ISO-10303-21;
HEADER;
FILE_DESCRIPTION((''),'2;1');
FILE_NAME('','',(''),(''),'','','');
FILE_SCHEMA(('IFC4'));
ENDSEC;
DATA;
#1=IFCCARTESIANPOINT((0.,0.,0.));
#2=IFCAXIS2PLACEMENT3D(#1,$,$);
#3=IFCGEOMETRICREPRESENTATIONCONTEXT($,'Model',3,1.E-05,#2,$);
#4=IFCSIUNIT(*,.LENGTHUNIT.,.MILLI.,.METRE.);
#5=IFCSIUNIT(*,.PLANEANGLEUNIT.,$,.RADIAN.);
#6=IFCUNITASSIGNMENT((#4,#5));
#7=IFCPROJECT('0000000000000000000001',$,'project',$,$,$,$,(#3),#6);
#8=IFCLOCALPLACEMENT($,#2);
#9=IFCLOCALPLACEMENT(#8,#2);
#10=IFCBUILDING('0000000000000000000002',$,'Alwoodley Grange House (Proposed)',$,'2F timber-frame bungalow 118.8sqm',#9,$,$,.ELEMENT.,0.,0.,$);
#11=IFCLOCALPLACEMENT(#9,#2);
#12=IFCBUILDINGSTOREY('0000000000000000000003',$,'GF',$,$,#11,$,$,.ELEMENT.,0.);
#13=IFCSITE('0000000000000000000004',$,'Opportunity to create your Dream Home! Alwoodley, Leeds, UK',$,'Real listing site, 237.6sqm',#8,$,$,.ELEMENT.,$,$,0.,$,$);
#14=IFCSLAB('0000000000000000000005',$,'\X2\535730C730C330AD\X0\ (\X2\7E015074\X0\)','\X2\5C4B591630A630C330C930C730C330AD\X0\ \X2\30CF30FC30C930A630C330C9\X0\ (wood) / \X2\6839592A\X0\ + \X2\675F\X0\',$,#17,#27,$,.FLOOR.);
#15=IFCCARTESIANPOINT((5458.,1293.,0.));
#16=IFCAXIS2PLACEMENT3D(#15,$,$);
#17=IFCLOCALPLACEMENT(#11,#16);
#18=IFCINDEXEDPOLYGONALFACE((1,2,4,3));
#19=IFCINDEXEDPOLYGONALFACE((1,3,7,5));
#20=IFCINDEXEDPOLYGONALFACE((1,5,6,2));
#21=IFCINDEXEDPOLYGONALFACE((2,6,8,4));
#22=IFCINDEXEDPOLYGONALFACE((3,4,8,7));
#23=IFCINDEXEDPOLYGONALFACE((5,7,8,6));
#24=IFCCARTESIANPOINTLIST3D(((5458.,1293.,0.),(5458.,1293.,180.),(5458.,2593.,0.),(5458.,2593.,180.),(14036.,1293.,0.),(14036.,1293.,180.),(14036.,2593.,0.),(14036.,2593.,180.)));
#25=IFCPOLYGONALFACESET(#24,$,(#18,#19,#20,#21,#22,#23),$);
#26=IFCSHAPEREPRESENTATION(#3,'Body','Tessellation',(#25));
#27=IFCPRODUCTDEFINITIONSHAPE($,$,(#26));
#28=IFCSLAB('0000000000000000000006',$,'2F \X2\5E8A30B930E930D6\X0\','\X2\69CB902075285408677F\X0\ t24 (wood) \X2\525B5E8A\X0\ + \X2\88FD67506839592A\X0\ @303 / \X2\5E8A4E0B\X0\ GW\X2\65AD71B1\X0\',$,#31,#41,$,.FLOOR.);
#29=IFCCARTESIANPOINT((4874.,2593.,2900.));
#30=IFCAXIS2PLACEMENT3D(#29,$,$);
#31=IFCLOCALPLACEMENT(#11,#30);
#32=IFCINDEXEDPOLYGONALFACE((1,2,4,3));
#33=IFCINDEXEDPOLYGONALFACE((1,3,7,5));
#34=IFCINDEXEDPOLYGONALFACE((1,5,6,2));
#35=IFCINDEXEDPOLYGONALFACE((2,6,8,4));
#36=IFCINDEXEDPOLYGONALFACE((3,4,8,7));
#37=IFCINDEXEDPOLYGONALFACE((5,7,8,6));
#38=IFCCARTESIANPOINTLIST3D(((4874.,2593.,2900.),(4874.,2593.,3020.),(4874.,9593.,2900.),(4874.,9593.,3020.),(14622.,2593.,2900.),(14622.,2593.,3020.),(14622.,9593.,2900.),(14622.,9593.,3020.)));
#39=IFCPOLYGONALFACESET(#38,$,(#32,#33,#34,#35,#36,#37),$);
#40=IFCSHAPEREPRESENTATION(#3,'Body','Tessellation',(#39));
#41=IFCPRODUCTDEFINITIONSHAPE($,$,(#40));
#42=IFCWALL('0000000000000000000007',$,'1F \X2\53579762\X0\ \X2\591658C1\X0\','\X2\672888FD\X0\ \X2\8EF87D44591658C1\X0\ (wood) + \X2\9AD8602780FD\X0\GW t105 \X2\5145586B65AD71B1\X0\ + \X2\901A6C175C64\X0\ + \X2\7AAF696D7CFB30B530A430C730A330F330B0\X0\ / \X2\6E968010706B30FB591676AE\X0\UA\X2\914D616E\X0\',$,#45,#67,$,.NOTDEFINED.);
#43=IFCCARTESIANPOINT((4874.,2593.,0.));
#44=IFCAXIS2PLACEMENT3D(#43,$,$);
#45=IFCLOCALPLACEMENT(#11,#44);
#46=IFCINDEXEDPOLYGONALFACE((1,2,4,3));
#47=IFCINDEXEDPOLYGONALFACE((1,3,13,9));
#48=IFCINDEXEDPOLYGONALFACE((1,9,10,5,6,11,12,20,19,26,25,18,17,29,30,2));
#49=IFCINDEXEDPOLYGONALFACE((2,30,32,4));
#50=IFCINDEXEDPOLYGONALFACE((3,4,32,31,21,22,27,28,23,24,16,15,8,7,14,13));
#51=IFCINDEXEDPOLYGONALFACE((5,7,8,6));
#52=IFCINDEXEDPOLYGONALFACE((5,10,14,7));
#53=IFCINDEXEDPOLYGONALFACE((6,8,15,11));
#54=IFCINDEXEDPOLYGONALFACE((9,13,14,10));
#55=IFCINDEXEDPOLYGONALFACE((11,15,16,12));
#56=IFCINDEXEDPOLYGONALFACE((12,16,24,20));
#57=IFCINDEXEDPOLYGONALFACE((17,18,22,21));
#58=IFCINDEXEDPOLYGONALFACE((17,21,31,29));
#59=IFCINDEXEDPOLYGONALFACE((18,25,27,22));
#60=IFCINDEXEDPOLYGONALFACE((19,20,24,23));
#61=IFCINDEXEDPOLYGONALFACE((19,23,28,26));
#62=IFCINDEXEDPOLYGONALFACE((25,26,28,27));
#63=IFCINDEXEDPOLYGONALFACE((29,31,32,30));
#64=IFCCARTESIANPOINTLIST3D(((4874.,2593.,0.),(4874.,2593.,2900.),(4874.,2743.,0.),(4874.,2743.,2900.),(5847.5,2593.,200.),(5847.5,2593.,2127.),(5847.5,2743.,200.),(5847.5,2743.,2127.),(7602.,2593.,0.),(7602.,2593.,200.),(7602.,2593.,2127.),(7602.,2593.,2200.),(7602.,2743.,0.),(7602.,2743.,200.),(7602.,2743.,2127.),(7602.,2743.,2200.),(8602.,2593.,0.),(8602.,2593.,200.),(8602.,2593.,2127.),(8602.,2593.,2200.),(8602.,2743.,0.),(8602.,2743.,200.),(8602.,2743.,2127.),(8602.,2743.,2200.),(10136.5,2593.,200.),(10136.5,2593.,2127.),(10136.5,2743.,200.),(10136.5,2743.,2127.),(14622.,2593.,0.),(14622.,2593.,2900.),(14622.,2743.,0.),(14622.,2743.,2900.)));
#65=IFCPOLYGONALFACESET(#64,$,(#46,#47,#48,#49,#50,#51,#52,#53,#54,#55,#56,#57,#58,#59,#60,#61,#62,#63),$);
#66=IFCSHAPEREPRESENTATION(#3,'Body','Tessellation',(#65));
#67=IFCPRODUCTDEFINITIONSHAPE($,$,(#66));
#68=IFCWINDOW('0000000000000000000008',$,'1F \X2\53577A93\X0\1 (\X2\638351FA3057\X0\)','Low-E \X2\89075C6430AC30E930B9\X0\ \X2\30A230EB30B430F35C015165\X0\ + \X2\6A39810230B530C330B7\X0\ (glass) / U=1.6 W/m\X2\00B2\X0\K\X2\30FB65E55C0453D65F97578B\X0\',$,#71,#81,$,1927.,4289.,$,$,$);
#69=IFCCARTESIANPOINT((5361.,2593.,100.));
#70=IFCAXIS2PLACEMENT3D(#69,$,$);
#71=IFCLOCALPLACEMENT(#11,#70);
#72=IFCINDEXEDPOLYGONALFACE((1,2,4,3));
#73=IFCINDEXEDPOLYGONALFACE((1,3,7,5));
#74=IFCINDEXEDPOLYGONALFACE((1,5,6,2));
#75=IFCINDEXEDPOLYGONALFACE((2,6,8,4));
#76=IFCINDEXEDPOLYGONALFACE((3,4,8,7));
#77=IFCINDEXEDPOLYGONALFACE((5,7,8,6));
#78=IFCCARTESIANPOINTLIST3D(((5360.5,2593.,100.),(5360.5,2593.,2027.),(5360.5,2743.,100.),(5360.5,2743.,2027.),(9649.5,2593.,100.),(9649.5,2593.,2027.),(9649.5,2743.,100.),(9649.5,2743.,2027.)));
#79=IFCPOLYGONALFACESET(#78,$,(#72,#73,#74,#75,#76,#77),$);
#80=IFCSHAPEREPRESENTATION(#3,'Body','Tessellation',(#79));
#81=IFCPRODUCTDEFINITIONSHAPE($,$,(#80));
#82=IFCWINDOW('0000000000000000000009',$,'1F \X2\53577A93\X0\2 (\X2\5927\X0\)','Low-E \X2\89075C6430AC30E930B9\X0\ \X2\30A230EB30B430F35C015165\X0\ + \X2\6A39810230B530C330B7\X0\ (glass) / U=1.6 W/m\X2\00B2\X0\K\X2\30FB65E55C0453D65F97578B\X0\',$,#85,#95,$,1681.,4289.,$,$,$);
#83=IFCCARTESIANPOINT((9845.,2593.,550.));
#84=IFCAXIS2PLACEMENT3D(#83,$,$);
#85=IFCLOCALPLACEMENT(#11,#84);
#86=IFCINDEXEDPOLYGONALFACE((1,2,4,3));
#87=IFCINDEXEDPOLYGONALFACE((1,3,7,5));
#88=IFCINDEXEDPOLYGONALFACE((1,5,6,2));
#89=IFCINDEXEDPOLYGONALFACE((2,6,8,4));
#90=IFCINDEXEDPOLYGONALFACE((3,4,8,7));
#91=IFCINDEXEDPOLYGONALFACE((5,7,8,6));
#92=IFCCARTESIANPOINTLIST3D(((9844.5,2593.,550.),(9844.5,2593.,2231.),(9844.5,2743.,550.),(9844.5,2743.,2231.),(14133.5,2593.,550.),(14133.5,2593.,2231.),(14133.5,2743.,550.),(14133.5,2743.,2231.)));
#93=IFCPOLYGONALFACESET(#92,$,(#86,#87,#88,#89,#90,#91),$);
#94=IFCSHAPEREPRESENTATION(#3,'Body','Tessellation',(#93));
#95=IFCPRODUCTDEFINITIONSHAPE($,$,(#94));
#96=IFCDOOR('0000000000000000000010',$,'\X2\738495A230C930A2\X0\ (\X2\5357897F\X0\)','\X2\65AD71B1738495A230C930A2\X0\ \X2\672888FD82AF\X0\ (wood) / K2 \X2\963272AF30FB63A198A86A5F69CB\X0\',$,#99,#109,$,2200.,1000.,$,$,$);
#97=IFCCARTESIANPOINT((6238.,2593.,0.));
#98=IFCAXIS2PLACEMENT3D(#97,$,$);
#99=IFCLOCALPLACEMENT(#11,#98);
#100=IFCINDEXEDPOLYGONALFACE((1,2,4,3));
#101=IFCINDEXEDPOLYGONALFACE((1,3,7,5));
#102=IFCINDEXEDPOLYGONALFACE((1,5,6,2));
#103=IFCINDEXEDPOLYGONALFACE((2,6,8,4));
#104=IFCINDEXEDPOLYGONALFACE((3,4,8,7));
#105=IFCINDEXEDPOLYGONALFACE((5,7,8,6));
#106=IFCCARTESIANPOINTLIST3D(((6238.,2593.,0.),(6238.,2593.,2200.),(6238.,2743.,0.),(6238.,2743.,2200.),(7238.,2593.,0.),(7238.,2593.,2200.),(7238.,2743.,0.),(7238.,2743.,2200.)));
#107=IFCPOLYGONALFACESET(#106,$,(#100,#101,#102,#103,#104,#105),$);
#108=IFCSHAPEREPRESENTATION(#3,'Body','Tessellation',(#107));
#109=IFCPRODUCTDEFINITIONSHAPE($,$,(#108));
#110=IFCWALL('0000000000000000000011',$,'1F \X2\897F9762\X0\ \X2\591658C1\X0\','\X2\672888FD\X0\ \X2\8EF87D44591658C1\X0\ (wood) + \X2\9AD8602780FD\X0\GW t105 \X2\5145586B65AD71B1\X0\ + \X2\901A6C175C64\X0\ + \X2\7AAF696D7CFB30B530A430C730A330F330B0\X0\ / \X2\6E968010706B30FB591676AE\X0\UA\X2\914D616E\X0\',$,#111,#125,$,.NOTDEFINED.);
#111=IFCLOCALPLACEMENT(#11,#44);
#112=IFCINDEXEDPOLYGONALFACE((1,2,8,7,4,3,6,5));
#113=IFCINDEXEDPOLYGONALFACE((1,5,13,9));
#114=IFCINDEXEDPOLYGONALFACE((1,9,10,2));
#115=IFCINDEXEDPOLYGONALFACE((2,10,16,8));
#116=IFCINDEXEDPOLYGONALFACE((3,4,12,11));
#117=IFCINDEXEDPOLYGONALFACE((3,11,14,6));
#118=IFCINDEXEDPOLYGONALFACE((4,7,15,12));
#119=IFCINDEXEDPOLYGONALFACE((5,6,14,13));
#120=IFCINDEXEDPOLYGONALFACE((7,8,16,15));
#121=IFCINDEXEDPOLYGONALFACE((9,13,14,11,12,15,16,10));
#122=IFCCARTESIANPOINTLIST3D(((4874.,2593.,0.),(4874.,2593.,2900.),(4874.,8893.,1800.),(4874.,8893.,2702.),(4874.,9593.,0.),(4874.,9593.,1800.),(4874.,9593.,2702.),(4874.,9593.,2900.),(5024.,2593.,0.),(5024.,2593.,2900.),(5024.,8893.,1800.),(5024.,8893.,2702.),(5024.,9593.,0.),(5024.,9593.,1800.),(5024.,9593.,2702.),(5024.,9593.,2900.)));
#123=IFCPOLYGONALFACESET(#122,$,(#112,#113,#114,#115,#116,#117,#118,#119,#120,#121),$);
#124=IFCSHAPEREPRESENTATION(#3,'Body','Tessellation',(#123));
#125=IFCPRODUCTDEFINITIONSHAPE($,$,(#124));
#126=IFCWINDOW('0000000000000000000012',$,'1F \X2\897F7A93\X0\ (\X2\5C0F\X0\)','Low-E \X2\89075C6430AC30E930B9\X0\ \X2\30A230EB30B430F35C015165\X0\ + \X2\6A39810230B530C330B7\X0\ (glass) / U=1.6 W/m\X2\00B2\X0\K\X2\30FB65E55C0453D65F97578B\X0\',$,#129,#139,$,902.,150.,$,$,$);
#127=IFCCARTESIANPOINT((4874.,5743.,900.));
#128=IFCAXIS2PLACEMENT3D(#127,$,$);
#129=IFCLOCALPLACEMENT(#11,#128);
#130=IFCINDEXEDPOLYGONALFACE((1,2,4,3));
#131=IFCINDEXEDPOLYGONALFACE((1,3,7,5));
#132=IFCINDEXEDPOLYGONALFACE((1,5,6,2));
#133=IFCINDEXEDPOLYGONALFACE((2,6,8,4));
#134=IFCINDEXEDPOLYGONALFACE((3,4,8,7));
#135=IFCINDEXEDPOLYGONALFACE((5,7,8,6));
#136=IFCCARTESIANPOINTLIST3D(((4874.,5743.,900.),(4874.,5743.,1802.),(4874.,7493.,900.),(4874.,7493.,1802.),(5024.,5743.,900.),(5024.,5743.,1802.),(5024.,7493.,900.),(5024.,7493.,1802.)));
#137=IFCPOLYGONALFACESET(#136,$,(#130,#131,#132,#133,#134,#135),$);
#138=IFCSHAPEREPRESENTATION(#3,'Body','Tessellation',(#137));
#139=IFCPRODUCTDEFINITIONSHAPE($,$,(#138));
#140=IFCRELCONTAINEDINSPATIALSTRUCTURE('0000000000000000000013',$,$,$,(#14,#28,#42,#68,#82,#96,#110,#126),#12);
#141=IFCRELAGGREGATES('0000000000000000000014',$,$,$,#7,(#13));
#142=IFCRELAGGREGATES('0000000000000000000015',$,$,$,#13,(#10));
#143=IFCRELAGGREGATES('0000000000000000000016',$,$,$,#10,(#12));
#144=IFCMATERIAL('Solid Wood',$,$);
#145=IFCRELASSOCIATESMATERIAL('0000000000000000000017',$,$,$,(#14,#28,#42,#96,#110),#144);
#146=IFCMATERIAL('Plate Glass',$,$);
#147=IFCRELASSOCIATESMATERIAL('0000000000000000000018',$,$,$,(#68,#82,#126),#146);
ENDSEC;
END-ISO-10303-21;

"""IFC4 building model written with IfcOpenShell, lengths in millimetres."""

from ifc_helpers import new_model, si_unit, frame, frame_2d, origin, place, context, project, spatial, rectangle, extrude, material, element, fill, save


model = new_model("IFC4")

# Units and contexts
model_context = context("Model", 3, precision=1e-05, world=origin())
ifc_project = project(units=[si_unit("LENGTHUNIT", "METRE", prefix="MILLI"), si_unit("PLANEANGLEUNIT", "RADIAN")], contexts=[model_context])

# Site, building, storey
site_placement = place(None, origin())
site = spatial("IfcSite", under=ifc_project, at=site_placement, Name="Opportunity to create your Dream Home! Alwoodley, Leeds, UK", ObjectType="Real listing site, 237.6sqm", CompositionType="ELEMENT", RefElevation=0.0)
building_placement = place(site_placement, origin())
building = spatial("IfcBuilding", under=site, at=building_placement, Name="Alwoodley Grange House (Proposed)", ObjectType="2F timber-frame bungalow 118.8sqm", CompositionType="ELEMENT", ElevationOfRefHeight=0.0, ElevationOfTerrain=0.0)
storey_placement = place(building_placement, origin())
storey = spatial("IfcBuildingStorey", under=building, at=storey_placement, Name="GF", CompositionType="ELEMENT", Elevation=0.0)

# Slabs
ifc_material_1 = material(Name="Solid Wood")
slab_1_placement = place(storey_placement, frame((5458.0, 1293.0, 0.0)))
element("IfcSlab", 1, at=slab_1_placement, inside=storey, material=ifc_material_1, Name="南デッキ (縁側)", Description="屋外ウッドデッキ ハードウッド (wood) / 根太 + 束", PredefinedType="FLOOR", context=model_context, shape_type="SweptSolid", body=[
    extrude(rectangle(XDim=8578.0, YDim=1300.0, at=frame_2d((4289.0, 650.0))), frame((5458.0, 1293.0, 0.0)), (0.0, 0.0, 1.0), 180.0),
])
slab_2_placement = place(storey_placement, frame((4874.0, 2593.0, 2900.0)))
element("IfcSlab", 2, at=slab_2_placement, inside=storey, material=ifc_material_1, Name="2F 床スラブ", Description="構造用合板 t24 (wood) 剛床 + 製材根太 @303 / 床下 GW断熱", PredefinedType="FLOOR", context=model_context, shape_type="SweptSolid", body=[
    extrude(rectangle(XDim=9748.0, YDim=7000.0, at=frame_2d((4874.0, 3500.0))), frame((4874.0, 2593.0, 2900.0)), (0.0, 0.0, 1.0), 120.0),
])

# Wall, openings, windows, door
wall_1_placement = place(storey_placement, frame((4874.0, 2593.0, 0.0)))
wall_1 = element("IfcWall", 3, at=wall_1_placement, inside=storey, material=ifc_material_1, Name="1F 南面 外壁", Description="木製 軸組外壁 (wood) + 高性能GW t105 充填断熱 + 通気層 + 窯業系サイディング / 準耐火・外皮UA配慮", PredefinedType="NOTDEFINED", context=model_context, shape_type="SweptSolid", body=[
    extrude(rectangle(XDim=9748.0, YDim=150.0, at=frame_2d((4874.0, 75.0))), frame((4874.0, 2593.0, 0.0)), (0.0, 0.0, 1.0), 2900.0),
])
opening_1_placement = place(storey_placement, frame((5361.0, 2593.0, 100.0)))
opening_1 = element("IfcOpeningElement", 4, at=opening_1_placement, cuts=wall_1, PredefinedType="NOTDEFINED", context=model_context, shape_type="SweptSolid", body=[
    extrude(rectangle(XDim=4289.0, YDim=150.0, at=frame_2d((2144.0, 75.0))), frame((5361.0, 2593.0, 100.0)), (0.0, 0.0, 1.0), 1927.0),
])
opening_2_placement = place(storey_placement, frame((9845.0, 2593.0, 550.0)))
opening_2 = element("IfcOpeningElement", 5, at=opening_2_placement, cuts=wall_1, PredefinedType="NOTDEFINED", context=model_context, shape_type="SweptSolid", body=[
    extrude(rectangle(XDim=4289.0, YDim=150.0, at=frame_2d((2144.0, 75.0))), frame((9845.0, 2593.0, 550.0)), (0.0, 0.0, 1.0), 1681.0),
])
opening_3_placement = place(storey_placement, frame((6238.0, 2593.0, 0.0)))
opening_3 = element("IfcOpeningElement", 6, at=opening_3_placement, cuts=wall_1, PredefinedType="NOTDEFINED", context=model_context, shape_type="SweptSolid", body=[
    extrude(rectangle(XDim=1000.0, YDim=150.0, at=frame_2d((500.0, 75.0))), frame((6238.0, 2593.0, 0.0)), (0.0, 0.0, 1.0), 2200.0),
])
ifc_material_2 = material(Name="Plate Glass")
window_1_placement = place(storey_placement, frame((5361.0, 2593.0, 100.0)))
window_1 = element("IfcWindow", 7, at=window_1_placement, inside=storey, material=ifc_material_2, Name="1F 南窓1 (掃出し)", Description="Low-E 複層ガラス アルゴン封入 + 樹脂サッシ (glass) / U=1.6 W/m²K・日射取得型", OverallHeight=1927.0, OverallWidth=4289.0, context=model_context, shape_type="SweptSolid", body=[
    extrude(rectangle(XDim=4289.0, YDim=150.0, at=frame_2d((2144.0, 75.0))), frame((5361.0, 2593.0, 100.0)), (0.0, 0.0, 1.0), 1927.0),
])
fill(opening_1, window_1)
window_2_placement = place(storey_placement, frame((9845.0, 2593.0, 550.0)))
window_2 = element("IfcWindow", 8, at=window_2_placement, inside=storey, material=ifc_material_2, Name="1F 南窓2 (大)", Description="Low-E 複層ガラス アルゴン封入 + 樹脂サッシ (glass) / U=1.6 W/m²K・日射取得型", OverallHeight=1681.0, OverallWidth=4289.0, context=model_context, shape_type="SweptSolid", body=[
    extrude(rectangle(XDim=4289.0, YDim=150.0, at=frame_2d((2144.0, 75.0))), frame((9845.0, 2593.0, 550.0)), (0.0, 0.0, 1.0), 1681.0),
])
fill(opening_2, window_2)
door_placement = place(storey_placement, frame((6238.0, 2593.0, 0.0)))
door = element("IfcDoor", 9, at=door_placement, inside=storey, material=ifc_material_1, Name="玄関ドア (南西)", Description="断熱玄関ドア 木製芯 (wood) / K2 防犯・採風機構", OverallHeight=2200.0, OverallWidth=1000.0, context=model_context, shape_type="SweptSolid", body=[
    extrude(rectangle(XDim=1000.0, YDim=150.0, at=frame_2d((500.0, 75.0))), frame((6238.0, 2593.0, 0.0)), (0.0, 0.0, 1.0), 2200.0),
])
fill(opening_3, door)

# Wall, opening, window
wall_2_placement = place(storey_placement, frame((4874.0, 2593.0, 0.0)))
wall_2 = element("IfcWall", 10, at=wall_2_placement, inside=storey, material=ifc_material_1, Name="1F 西面 外壁", Description="木製 軸組外壁 (wood) + 高性能GW t105 充填断熱 + 通気層 + 窯業系サイディング / 準耐火・外皮UA配慮", PredefinedType="NOTDEFINED", context=model_context, shape_type="SweptSolid", body=[
    extrude(rectangle(XDim=150.0, YDim=7000.0, at=frame_2d((75.0, 3500.0))), frame((4874.0, 2593.0, 0.0)), (0.0, 0.0, 1.0), 2900.0),
])
opening_4_placement = place(storey_placement, frame((4874.0, 5743.0, 900.0)))
opening_4 = element("IfcOpeningElement", 11, at=opening_4_placement, cuts=wall_2, PredefinedType="NOTDEFINED", context=model_context, shape_type="SweptSolid", body=[
    extrude(rectangle(XDim=150.0, YDim=1750.0, at=frame_2d((75.0, 875.0))), frame((4874.0, 5743.0, 900.0)), (0.0, 0.0, 1.0), 902.0),
])
window_3_placement = place(storey_placement, frame((4874.0, 5743.0, 900.0)))
window_3 = element("IfcWindow", 12, at=window_3_placement, inside=storey, material=ifc_material_2, Name="1F 西窓 (小)", Description="Low-E 複層ガラス アルゴン封入 + 樹脂サッシ (glass) / U=1.6 W/m²K・日射取得型", OverallHeight=902.0, OverallWidth=150.0, context=model_context, shape_type="SweptSolid", body=[
    extrude(rectangle(XDim=150.0, YDim=1750.0, at=frame_2d((75.0, 875.0))), frame((4874.0, 5743.0, 900.0)), (0.0, 0.0, 1.0), 902.0),
])
fill(opening_4, window_3)

save(model, "model.ifc")
